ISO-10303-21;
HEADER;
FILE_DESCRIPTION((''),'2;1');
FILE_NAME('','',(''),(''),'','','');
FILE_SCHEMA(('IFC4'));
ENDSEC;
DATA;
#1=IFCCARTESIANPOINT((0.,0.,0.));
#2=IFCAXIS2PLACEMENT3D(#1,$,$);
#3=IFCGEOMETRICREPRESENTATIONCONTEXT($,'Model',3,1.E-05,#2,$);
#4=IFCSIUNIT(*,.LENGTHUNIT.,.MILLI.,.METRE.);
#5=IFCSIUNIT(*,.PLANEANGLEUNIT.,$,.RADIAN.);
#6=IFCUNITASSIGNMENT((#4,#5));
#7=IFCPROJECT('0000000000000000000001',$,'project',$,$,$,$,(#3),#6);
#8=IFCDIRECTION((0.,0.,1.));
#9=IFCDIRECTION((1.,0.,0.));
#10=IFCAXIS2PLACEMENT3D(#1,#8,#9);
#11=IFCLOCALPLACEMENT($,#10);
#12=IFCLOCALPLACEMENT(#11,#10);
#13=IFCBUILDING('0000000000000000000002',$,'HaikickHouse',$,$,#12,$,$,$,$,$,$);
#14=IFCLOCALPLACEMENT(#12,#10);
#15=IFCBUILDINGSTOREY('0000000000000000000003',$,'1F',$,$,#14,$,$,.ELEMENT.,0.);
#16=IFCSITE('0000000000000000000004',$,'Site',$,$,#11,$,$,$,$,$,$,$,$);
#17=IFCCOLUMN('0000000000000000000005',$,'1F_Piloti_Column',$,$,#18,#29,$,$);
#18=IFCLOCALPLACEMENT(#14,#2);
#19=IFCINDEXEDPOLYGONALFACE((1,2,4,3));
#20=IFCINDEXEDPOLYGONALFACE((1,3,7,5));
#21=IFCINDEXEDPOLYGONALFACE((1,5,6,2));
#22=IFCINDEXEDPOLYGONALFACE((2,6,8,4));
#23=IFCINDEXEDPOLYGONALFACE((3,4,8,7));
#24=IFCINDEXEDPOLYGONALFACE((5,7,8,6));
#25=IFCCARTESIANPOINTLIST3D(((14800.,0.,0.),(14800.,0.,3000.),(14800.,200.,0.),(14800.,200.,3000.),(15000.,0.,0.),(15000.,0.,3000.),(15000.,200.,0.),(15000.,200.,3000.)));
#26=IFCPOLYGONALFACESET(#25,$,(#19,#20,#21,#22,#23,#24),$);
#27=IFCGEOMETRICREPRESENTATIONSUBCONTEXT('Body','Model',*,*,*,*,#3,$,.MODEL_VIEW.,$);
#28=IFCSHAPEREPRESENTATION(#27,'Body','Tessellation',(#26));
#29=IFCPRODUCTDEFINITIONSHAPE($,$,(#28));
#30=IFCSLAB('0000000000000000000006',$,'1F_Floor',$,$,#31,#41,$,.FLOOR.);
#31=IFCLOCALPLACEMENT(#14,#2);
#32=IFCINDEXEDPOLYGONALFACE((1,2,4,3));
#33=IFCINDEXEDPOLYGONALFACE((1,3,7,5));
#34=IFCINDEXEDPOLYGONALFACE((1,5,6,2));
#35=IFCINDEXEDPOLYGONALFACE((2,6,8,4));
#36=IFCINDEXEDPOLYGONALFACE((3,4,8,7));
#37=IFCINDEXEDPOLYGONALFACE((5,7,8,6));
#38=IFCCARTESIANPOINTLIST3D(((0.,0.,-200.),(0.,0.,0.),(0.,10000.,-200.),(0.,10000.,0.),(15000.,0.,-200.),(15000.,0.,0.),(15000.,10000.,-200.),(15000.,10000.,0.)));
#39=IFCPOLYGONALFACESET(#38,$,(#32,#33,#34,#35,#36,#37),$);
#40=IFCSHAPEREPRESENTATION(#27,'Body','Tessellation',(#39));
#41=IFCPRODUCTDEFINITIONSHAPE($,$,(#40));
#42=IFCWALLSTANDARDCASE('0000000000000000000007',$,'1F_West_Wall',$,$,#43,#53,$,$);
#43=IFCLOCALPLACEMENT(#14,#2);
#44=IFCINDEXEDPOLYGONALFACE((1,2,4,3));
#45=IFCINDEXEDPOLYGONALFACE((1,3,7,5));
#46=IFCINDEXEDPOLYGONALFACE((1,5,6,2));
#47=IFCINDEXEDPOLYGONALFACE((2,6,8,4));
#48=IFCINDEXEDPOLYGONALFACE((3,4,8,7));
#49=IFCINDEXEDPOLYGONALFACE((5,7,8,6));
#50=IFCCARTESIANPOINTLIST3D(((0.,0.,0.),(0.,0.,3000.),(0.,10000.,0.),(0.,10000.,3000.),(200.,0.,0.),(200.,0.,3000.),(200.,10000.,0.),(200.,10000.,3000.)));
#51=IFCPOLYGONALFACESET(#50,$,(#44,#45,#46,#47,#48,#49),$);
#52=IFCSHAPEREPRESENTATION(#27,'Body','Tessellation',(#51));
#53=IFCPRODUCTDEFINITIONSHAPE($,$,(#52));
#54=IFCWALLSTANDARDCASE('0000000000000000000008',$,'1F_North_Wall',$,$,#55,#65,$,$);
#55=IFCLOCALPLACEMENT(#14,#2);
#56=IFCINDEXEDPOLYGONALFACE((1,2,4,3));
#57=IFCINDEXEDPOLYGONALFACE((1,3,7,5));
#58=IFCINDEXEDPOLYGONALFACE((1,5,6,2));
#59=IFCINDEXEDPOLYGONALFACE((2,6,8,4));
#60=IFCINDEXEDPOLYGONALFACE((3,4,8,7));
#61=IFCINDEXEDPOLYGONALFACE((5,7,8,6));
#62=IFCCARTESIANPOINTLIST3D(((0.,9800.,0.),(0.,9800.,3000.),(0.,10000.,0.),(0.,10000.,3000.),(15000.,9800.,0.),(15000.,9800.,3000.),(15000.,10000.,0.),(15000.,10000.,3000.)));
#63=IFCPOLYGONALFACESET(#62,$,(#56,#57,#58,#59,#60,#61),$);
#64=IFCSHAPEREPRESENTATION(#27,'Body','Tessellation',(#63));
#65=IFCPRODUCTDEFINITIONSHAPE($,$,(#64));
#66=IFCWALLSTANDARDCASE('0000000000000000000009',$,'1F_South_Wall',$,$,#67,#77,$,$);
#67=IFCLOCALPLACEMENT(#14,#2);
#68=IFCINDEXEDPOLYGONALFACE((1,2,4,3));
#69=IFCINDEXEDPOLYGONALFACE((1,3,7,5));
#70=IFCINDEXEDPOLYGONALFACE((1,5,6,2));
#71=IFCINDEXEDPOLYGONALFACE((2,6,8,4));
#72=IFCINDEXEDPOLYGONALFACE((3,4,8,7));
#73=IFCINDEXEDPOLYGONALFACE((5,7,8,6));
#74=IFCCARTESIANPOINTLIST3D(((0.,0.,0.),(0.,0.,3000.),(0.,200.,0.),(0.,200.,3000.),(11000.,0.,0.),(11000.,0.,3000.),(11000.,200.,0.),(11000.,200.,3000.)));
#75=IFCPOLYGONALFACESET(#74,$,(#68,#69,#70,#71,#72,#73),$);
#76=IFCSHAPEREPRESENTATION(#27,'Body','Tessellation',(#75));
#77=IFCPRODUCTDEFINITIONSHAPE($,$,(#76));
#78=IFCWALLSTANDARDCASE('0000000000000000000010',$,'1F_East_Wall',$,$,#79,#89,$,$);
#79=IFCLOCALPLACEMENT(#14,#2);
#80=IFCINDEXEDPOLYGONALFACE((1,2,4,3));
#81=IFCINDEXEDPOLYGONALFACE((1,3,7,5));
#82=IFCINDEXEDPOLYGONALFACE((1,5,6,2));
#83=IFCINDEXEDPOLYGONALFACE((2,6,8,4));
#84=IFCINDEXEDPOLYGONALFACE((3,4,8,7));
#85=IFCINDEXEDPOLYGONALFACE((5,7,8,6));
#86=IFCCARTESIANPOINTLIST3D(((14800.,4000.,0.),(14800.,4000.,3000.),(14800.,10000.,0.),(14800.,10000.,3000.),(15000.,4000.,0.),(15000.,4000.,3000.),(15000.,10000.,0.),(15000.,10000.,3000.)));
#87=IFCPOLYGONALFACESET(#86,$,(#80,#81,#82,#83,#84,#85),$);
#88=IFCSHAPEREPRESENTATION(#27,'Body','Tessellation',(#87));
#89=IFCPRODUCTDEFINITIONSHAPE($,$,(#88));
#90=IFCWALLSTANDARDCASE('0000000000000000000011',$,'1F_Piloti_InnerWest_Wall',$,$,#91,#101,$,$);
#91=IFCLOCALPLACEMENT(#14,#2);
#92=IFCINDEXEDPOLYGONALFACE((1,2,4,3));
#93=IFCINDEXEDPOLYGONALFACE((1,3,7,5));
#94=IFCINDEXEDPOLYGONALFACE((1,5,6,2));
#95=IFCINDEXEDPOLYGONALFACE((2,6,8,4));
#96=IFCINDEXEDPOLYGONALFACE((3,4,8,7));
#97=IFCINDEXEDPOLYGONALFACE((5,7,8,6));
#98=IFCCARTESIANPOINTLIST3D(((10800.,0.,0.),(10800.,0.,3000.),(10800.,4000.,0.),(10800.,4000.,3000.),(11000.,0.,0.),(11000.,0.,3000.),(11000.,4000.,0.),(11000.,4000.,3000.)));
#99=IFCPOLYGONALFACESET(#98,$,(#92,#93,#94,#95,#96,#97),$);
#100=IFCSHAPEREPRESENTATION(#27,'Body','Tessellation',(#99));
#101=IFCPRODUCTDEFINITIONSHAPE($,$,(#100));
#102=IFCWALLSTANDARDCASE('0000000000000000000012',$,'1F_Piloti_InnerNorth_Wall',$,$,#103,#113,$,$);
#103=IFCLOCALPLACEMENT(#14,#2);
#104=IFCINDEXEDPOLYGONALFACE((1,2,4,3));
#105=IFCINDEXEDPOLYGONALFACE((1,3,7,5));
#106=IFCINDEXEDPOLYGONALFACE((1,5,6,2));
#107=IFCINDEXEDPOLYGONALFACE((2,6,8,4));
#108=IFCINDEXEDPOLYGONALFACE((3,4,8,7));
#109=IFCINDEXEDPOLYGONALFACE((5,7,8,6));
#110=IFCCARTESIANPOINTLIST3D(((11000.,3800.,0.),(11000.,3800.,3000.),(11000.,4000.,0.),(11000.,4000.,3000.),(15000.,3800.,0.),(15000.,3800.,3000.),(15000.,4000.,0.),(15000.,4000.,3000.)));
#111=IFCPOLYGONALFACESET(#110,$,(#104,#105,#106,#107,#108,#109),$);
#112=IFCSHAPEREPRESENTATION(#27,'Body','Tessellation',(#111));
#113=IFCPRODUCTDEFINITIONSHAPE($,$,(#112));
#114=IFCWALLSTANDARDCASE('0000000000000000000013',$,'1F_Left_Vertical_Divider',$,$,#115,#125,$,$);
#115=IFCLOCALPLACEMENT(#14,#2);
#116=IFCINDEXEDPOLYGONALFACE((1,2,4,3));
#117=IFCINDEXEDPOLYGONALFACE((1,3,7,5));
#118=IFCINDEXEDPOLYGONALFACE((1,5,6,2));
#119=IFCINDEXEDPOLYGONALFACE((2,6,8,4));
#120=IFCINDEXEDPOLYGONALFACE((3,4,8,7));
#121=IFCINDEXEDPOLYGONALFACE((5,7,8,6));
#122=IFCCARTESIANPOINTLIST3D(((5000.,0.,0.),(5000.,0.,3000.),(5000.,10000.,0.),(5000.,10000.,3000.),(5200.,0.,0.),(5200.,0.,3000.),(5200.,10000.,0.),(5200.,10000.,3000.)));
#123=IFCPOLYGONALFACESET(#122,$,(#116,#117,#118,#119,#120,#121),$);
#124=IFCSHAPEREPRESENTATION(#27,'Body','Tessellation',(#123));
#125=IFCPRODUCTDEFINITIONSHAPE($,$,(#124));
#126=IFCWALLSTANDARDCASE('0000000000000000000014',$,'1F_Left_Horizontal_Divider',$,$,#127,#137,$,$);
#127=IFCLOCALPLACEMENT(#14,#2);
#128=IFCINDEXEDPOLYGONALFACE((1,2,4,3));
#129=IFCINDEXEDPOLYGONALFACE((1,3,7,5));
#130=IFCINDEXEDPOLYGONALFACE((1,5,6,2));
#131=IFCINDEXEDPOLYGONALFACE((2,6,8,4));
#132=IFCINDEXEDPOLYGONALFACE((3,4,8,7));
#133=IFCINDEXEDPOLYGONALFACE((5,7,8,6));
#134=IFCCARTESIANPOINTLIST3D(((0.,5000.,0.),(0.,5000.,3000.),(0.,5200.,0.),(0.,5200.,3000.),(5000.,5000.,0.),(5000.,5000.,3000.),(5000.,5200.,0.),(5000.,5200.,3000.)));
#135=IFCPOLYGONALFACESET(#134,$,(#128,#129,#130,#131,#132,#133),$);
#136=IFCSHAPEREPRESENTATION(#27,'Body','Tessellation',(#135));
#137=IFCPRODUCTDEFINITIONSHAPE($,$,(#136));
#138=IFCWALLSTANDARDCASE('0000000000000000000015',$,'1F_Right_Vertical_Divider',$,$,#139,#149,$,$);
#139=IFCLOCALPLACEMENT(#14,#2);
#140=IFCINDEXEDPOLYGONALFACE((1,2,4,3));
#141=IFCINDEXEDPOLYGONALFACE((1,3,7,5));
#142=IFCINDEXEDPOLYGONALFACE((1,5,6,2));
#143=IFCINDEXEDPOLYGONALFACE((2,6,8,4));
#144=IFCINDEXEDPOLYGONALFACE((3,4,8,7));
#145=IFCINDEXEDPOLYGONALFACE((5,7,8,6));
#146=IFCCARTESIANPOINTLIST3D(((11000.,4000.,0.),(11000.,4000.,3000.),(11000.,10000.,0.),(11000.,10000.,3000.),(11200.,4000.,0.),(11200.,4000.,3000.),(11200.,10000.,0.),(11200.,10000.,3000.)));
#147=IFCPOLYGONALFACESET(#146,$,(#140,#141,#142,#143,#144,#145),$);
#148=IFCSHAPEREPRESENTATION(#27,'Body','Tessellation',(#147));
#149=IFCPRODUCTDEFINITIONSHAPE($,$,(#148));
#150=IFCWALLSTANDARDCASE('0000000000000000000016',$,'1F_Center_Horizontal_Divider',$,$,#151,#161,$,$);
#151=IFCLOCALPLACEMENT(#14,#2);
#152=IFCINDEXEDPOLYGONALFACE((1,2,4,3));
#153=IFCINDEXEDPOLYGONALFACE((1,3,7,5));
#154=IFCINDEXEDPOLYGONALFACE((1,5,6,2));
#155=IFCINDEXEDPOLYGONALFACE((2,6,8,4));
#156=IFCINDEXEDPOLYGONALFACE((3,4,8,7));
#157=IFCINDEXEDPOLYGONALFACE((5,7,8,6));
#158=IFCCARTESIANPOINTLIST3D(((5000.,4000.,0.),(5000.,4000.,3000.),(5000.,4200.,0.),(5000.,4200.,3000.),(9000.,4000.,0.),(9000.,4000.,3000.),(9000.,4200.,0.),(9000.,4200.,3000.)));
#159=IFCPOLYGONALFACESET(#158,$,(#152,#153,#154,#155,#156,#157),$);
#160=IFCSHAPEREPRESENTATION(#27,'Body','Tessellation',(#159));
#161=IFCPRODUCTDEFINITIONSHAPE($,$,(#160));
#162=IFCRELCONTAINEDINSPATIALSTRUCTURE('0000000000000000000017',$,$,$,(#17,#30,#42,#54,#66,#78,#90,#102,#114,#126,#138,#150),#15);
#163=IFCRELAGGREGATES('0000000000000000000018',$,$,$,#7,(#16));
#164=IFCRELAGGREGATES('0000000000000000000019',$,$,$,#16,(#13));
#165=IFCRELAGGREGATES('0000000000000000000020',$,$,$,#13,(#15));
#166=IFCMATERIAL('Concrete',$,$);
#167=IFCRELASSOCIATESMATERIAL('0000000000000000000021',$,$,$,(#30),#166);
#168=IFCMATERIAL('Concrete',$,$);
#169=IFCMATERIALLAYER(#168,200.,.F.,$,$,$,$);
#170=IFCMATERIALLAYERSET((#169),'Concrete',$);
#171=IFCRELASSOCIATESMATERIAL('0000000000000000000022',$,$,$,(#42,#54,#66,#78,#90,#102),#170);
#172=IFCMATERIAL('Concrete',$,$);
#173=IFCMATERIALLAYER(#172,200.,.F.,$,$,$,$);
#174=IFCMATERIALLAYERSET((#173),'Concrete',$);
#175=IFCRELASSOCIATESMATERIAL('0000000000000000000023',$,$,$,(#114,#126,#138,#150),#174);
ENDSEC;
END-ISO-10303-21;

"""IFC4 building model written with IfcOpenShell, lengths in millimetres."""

from ifc_helpers import new_model, si_unit, frame, origin, origin_with_axes, place, context, subcontext, project, spatial, rectangle, extrude, material, layer, layer_set, layer_usage, element, save


model = new_model("IFC4")

# Units and contexts
model_context = context("Model", 3, precision=1e-05, world=origin())
body_context = subcontext(model_context, "Body", "Model", "MODEL_VIEW")
ifc_project = project(units=[si_unit("LENGTHUNIT", "METRE", prefix="MILLI"), si_unit("PLANEANGLEUNIT", "RADIAN")], contexts=[model_context])

# Site, building, storey
site_placement = place(None, origin_with_axes())
site = spatial("IfcSite", under=ifc_project, at=site_placement, Name="Site")
building_placement = place(site_placement, origin_with_axes())
building = spatial("IfcBuilding", under=site, at=building_placement, Name="HaikickHouse")
storey_placement = place(building_placement, origin_with_axes())
storey = spatial("IfcBuildingStorey", under=building, at=storey_placement, Name="1F", CompositionType="ELEMENT", Elevation=0.0)

# Column
column_placement = place(None, frame((14800.0, 0.0, 0.0), z_axis=(0.0, 0.0, 1.0), x_axis=(1.0, 0.0, 0.0)))
element("IfcColumn", 1, at=column_placement, inside=storey, Name="1F_Piloti_Column", context=body_context, shape_type="SweptSolid", body=[
    extrude(rectangle(XDim=200.0, YDim=200.0), frame((100.0, 100.0, 0.0)), (0.0, 0.0, 1.0), 3000.0),
])

# Slab
ifc_material_1 = material(Name="Concrete")
slab_placement = place(None, frame((0.0, 0.0, -200.0), z_axis=(0.0, 0.0, 1.0), x_axis=(1.0, 0.0, 0.0)))
element("IfcSlab", 2, at=slab_placement, inside=storey, material=ifc_material_1, Name="1F_Floor", PredefinedType="FLOOR", context=body_context, shape_type="SweptSolid", body=[
    extrude(rectangle(XDim=15000.0, YDim=10000.0), frame((7500.0, 5000.0, 0.0)), (0.0, 0.0, 1.0), 200.0),
])

# Walls
ifc_material_2 = material(Name="Concrete")
ifc_layer_1 = layer(ifc_material_2, 200.0, ventilated=False)
ifc_layer_set_1 = layer_set([ifc_layer_1], Name="Concrete")
ifc_layer_usage_1 = layer_usage(ifc_layer_set_1, "AXIS2", "POSITIVE", 0.0)
wall_1_placement = place(None, origin_with_axes())
element("IfcWallStandardCase", 3, at=wall_1_placement, inside=storey, material=ifc_layer_usage_1, Name="1F_West_Wall", context=body_context, shape_type="SweptSolid", body=[
    extrude(rectangle(XDim=200.0, YDim=10000.0), frame((100.0, 5000.0, 0.0)), (0.0, 0.0, 1.0), 3000.0),
])
wall_2_placement = place(None, frame((0.0, 9800.0, 0.0), z_axis=(0.0, 0.0, 1.0), x_axis=(1.0, 0.0, 0.0)))
element("IfcWallStandardCase", 4, at=wall_2_placement, inside=storey, material=ifc_layer_usage_1, Name="1F_North_Wall", context=body_context, shape_type="SweptSolid", body=[
    extrude(rectangle(XDim=15000.0, YDim=200.0), frame((7500.0, 100.0, 0.0)), (0.0, 0.0, 1.0), 3000.0),
])
wall_3_placement = place(None, origin_with_axes())
element("IfcWallStandardCase", 5, at=wall_3_placement, inside=storey, material=ifc_layer_usage_1, Name="1F_South_Wall", context=body_context, shape_type="SweptSolid", body=[
    extrude(rectangle(XDim=11000.0, YDim=200.0), frame((5500.0, 100.0, 0.0)), (0.0, 0.0, 1.0), 3000.0),
])
wall_4_placement = place(None, frame((14800.0, 4000.0, 0.0), z_axis=(0.0, 0.0, 1.0), x_axis=(1.0, 0.0, 0.0)))
element("IfcWallStandardCase", 6, at=wall_4_placement, inside=storey, material=ifc_layer_usage_1, Name="1F_East_Wall", context=body_context, shape_type="SweptSolid", body=[
    extrude(rectangle(XDim=200.0, YDim=6000.0), frame((100.0, 3000.0, 0.0)), (0.0, 0.0, 1.0), 3000.0),
])
wall_5_placement = place(None, frame((10800.0, 0.0, 0.0), z_axis=(0.0, 0.0, 1.0), x_axis=(1.0, 0.0, 0.0)))
element("IfcWallStandardCase", 7, at=wall_5_placement, inside=storey, material=ifc_layer_usage_1, Name="1F_Piloti_InnerWest_Wall", context=body_context, shape_type="SweptSolid", body=[
    extrude(rectangle(XDim=200.0, YDim=4000.0), frame((100.0, 2000.0, 0.0)), (0.0, 0.0, 1.0), 3000.0),
])
wall_6_placement = place(None, frame((11000.0, 3800.0, 0.0), z_axis=(0.0, 0.0, 1.0), x_axis=(1.0, 0.0, 0.0)))
element("IfcWallStandardCase", 8, at=wall_6_placement, inside=storey, material=ifc_layer_usage_1, Name="1F_Piloti_InnerNorth_Wall", context=body_context, shape_type="SweptSolid", body=[
    extrude(rectangle(XDim=4000.0, YDim=200.0), frame((2000.0, 100.0, 0.0)), (0.0, 0.0, 1.0), 3000.0),
])
ifc_material_3 = material(Name="Concrete")
ifc_layer_2 = layer(ifc_material_3, 200.0, ventilated=False)
ifc_layer_set_2 = layer_set([ifc_layer_2], Name="Concrete")
ifc_layer_usage_2 = layer_usage(ifc_layer_set_2, "AXIS2", "POSITIVE", 0.0)
wall_7_placement = place(None, frame((5000.0, 0.0, 0.0), z_axis=(0.0, 0.0, 1.0), x_axis=(1.0, 0.0, 0.0)))
element("IfcWallStandardCase", 9, at=wall_7_placement, inside=storey, material=ifc_layer_usage_2, Name="1F_Left_Vertical_Divider", context=body_context, shape_type="SweptSolid", body=[
    extrude(rectangle(XDim=200.0, YDim=10000.0), frame((100.0, 5000.0, 0.0)), (0.0, 0.0, 1.0), 3000.0),
])
wall_8_placement = place(None, frame((0.0, 5000.0, 0.0), z_axis=(0.0, 0.0, 1.0), x_axis=(1.0, 0.0, 0.0)))
element("IfcWallStandardCase", 10, at=wall_8_placement, inside=storey, material=ifc_layer_usage_2, Name="1F_Left_Horizontal_Divider", context=body_context, shape_type="SweptSolid", body=[
    extrude(rectangle(XDim=5000.0, YDim=200.0), frame((2500.0, 100.0, 0.0)), (0.0, 0.0, 1.0), 3000.0),
])
wall_9_placement = place(None, frame((11000.0, 4000.0, 0.0), z_axis=(0.0, 0.0, 1.0), x_axis=(1.0, 0.0, 0.0)))
element("IfcWallStandardCase", 11, at=wall_9_placement, inside=storey, material=ifc_layer_usage_2, Name="1F_Right_Vertical_Divider", context=body_context, shape_type="SweptSolid", body=[
    extrude(rectangle(XDim=200.0, YDim=6000.0), frame((100.0, 3000.0, 0.0)), (0.0, 0.0, 1.0), 3000.0),
])
wall_10_placement = place(None, frame((5000.0, 4000.0, 0.0), z_axis=(0.0, 0.0, 1.0), x_axis=(1.0, 0.0, 0.0)))
element("IfcWallStandardCase", 12, at=wall_10_placement, inside=storey, material=ifc_layer_usage_2, Name="1F_Center_Horizontal_Divider", context=body_context, shape_type="SweptSolid", body=[
    extrude(rectangle(XDim=4000.0, YDim=200.0), frame((2000.0, 100.0, 0.0)), (0.0, 0.0, 1.0), 3000.0),
])

save(model, "model.ifc")
